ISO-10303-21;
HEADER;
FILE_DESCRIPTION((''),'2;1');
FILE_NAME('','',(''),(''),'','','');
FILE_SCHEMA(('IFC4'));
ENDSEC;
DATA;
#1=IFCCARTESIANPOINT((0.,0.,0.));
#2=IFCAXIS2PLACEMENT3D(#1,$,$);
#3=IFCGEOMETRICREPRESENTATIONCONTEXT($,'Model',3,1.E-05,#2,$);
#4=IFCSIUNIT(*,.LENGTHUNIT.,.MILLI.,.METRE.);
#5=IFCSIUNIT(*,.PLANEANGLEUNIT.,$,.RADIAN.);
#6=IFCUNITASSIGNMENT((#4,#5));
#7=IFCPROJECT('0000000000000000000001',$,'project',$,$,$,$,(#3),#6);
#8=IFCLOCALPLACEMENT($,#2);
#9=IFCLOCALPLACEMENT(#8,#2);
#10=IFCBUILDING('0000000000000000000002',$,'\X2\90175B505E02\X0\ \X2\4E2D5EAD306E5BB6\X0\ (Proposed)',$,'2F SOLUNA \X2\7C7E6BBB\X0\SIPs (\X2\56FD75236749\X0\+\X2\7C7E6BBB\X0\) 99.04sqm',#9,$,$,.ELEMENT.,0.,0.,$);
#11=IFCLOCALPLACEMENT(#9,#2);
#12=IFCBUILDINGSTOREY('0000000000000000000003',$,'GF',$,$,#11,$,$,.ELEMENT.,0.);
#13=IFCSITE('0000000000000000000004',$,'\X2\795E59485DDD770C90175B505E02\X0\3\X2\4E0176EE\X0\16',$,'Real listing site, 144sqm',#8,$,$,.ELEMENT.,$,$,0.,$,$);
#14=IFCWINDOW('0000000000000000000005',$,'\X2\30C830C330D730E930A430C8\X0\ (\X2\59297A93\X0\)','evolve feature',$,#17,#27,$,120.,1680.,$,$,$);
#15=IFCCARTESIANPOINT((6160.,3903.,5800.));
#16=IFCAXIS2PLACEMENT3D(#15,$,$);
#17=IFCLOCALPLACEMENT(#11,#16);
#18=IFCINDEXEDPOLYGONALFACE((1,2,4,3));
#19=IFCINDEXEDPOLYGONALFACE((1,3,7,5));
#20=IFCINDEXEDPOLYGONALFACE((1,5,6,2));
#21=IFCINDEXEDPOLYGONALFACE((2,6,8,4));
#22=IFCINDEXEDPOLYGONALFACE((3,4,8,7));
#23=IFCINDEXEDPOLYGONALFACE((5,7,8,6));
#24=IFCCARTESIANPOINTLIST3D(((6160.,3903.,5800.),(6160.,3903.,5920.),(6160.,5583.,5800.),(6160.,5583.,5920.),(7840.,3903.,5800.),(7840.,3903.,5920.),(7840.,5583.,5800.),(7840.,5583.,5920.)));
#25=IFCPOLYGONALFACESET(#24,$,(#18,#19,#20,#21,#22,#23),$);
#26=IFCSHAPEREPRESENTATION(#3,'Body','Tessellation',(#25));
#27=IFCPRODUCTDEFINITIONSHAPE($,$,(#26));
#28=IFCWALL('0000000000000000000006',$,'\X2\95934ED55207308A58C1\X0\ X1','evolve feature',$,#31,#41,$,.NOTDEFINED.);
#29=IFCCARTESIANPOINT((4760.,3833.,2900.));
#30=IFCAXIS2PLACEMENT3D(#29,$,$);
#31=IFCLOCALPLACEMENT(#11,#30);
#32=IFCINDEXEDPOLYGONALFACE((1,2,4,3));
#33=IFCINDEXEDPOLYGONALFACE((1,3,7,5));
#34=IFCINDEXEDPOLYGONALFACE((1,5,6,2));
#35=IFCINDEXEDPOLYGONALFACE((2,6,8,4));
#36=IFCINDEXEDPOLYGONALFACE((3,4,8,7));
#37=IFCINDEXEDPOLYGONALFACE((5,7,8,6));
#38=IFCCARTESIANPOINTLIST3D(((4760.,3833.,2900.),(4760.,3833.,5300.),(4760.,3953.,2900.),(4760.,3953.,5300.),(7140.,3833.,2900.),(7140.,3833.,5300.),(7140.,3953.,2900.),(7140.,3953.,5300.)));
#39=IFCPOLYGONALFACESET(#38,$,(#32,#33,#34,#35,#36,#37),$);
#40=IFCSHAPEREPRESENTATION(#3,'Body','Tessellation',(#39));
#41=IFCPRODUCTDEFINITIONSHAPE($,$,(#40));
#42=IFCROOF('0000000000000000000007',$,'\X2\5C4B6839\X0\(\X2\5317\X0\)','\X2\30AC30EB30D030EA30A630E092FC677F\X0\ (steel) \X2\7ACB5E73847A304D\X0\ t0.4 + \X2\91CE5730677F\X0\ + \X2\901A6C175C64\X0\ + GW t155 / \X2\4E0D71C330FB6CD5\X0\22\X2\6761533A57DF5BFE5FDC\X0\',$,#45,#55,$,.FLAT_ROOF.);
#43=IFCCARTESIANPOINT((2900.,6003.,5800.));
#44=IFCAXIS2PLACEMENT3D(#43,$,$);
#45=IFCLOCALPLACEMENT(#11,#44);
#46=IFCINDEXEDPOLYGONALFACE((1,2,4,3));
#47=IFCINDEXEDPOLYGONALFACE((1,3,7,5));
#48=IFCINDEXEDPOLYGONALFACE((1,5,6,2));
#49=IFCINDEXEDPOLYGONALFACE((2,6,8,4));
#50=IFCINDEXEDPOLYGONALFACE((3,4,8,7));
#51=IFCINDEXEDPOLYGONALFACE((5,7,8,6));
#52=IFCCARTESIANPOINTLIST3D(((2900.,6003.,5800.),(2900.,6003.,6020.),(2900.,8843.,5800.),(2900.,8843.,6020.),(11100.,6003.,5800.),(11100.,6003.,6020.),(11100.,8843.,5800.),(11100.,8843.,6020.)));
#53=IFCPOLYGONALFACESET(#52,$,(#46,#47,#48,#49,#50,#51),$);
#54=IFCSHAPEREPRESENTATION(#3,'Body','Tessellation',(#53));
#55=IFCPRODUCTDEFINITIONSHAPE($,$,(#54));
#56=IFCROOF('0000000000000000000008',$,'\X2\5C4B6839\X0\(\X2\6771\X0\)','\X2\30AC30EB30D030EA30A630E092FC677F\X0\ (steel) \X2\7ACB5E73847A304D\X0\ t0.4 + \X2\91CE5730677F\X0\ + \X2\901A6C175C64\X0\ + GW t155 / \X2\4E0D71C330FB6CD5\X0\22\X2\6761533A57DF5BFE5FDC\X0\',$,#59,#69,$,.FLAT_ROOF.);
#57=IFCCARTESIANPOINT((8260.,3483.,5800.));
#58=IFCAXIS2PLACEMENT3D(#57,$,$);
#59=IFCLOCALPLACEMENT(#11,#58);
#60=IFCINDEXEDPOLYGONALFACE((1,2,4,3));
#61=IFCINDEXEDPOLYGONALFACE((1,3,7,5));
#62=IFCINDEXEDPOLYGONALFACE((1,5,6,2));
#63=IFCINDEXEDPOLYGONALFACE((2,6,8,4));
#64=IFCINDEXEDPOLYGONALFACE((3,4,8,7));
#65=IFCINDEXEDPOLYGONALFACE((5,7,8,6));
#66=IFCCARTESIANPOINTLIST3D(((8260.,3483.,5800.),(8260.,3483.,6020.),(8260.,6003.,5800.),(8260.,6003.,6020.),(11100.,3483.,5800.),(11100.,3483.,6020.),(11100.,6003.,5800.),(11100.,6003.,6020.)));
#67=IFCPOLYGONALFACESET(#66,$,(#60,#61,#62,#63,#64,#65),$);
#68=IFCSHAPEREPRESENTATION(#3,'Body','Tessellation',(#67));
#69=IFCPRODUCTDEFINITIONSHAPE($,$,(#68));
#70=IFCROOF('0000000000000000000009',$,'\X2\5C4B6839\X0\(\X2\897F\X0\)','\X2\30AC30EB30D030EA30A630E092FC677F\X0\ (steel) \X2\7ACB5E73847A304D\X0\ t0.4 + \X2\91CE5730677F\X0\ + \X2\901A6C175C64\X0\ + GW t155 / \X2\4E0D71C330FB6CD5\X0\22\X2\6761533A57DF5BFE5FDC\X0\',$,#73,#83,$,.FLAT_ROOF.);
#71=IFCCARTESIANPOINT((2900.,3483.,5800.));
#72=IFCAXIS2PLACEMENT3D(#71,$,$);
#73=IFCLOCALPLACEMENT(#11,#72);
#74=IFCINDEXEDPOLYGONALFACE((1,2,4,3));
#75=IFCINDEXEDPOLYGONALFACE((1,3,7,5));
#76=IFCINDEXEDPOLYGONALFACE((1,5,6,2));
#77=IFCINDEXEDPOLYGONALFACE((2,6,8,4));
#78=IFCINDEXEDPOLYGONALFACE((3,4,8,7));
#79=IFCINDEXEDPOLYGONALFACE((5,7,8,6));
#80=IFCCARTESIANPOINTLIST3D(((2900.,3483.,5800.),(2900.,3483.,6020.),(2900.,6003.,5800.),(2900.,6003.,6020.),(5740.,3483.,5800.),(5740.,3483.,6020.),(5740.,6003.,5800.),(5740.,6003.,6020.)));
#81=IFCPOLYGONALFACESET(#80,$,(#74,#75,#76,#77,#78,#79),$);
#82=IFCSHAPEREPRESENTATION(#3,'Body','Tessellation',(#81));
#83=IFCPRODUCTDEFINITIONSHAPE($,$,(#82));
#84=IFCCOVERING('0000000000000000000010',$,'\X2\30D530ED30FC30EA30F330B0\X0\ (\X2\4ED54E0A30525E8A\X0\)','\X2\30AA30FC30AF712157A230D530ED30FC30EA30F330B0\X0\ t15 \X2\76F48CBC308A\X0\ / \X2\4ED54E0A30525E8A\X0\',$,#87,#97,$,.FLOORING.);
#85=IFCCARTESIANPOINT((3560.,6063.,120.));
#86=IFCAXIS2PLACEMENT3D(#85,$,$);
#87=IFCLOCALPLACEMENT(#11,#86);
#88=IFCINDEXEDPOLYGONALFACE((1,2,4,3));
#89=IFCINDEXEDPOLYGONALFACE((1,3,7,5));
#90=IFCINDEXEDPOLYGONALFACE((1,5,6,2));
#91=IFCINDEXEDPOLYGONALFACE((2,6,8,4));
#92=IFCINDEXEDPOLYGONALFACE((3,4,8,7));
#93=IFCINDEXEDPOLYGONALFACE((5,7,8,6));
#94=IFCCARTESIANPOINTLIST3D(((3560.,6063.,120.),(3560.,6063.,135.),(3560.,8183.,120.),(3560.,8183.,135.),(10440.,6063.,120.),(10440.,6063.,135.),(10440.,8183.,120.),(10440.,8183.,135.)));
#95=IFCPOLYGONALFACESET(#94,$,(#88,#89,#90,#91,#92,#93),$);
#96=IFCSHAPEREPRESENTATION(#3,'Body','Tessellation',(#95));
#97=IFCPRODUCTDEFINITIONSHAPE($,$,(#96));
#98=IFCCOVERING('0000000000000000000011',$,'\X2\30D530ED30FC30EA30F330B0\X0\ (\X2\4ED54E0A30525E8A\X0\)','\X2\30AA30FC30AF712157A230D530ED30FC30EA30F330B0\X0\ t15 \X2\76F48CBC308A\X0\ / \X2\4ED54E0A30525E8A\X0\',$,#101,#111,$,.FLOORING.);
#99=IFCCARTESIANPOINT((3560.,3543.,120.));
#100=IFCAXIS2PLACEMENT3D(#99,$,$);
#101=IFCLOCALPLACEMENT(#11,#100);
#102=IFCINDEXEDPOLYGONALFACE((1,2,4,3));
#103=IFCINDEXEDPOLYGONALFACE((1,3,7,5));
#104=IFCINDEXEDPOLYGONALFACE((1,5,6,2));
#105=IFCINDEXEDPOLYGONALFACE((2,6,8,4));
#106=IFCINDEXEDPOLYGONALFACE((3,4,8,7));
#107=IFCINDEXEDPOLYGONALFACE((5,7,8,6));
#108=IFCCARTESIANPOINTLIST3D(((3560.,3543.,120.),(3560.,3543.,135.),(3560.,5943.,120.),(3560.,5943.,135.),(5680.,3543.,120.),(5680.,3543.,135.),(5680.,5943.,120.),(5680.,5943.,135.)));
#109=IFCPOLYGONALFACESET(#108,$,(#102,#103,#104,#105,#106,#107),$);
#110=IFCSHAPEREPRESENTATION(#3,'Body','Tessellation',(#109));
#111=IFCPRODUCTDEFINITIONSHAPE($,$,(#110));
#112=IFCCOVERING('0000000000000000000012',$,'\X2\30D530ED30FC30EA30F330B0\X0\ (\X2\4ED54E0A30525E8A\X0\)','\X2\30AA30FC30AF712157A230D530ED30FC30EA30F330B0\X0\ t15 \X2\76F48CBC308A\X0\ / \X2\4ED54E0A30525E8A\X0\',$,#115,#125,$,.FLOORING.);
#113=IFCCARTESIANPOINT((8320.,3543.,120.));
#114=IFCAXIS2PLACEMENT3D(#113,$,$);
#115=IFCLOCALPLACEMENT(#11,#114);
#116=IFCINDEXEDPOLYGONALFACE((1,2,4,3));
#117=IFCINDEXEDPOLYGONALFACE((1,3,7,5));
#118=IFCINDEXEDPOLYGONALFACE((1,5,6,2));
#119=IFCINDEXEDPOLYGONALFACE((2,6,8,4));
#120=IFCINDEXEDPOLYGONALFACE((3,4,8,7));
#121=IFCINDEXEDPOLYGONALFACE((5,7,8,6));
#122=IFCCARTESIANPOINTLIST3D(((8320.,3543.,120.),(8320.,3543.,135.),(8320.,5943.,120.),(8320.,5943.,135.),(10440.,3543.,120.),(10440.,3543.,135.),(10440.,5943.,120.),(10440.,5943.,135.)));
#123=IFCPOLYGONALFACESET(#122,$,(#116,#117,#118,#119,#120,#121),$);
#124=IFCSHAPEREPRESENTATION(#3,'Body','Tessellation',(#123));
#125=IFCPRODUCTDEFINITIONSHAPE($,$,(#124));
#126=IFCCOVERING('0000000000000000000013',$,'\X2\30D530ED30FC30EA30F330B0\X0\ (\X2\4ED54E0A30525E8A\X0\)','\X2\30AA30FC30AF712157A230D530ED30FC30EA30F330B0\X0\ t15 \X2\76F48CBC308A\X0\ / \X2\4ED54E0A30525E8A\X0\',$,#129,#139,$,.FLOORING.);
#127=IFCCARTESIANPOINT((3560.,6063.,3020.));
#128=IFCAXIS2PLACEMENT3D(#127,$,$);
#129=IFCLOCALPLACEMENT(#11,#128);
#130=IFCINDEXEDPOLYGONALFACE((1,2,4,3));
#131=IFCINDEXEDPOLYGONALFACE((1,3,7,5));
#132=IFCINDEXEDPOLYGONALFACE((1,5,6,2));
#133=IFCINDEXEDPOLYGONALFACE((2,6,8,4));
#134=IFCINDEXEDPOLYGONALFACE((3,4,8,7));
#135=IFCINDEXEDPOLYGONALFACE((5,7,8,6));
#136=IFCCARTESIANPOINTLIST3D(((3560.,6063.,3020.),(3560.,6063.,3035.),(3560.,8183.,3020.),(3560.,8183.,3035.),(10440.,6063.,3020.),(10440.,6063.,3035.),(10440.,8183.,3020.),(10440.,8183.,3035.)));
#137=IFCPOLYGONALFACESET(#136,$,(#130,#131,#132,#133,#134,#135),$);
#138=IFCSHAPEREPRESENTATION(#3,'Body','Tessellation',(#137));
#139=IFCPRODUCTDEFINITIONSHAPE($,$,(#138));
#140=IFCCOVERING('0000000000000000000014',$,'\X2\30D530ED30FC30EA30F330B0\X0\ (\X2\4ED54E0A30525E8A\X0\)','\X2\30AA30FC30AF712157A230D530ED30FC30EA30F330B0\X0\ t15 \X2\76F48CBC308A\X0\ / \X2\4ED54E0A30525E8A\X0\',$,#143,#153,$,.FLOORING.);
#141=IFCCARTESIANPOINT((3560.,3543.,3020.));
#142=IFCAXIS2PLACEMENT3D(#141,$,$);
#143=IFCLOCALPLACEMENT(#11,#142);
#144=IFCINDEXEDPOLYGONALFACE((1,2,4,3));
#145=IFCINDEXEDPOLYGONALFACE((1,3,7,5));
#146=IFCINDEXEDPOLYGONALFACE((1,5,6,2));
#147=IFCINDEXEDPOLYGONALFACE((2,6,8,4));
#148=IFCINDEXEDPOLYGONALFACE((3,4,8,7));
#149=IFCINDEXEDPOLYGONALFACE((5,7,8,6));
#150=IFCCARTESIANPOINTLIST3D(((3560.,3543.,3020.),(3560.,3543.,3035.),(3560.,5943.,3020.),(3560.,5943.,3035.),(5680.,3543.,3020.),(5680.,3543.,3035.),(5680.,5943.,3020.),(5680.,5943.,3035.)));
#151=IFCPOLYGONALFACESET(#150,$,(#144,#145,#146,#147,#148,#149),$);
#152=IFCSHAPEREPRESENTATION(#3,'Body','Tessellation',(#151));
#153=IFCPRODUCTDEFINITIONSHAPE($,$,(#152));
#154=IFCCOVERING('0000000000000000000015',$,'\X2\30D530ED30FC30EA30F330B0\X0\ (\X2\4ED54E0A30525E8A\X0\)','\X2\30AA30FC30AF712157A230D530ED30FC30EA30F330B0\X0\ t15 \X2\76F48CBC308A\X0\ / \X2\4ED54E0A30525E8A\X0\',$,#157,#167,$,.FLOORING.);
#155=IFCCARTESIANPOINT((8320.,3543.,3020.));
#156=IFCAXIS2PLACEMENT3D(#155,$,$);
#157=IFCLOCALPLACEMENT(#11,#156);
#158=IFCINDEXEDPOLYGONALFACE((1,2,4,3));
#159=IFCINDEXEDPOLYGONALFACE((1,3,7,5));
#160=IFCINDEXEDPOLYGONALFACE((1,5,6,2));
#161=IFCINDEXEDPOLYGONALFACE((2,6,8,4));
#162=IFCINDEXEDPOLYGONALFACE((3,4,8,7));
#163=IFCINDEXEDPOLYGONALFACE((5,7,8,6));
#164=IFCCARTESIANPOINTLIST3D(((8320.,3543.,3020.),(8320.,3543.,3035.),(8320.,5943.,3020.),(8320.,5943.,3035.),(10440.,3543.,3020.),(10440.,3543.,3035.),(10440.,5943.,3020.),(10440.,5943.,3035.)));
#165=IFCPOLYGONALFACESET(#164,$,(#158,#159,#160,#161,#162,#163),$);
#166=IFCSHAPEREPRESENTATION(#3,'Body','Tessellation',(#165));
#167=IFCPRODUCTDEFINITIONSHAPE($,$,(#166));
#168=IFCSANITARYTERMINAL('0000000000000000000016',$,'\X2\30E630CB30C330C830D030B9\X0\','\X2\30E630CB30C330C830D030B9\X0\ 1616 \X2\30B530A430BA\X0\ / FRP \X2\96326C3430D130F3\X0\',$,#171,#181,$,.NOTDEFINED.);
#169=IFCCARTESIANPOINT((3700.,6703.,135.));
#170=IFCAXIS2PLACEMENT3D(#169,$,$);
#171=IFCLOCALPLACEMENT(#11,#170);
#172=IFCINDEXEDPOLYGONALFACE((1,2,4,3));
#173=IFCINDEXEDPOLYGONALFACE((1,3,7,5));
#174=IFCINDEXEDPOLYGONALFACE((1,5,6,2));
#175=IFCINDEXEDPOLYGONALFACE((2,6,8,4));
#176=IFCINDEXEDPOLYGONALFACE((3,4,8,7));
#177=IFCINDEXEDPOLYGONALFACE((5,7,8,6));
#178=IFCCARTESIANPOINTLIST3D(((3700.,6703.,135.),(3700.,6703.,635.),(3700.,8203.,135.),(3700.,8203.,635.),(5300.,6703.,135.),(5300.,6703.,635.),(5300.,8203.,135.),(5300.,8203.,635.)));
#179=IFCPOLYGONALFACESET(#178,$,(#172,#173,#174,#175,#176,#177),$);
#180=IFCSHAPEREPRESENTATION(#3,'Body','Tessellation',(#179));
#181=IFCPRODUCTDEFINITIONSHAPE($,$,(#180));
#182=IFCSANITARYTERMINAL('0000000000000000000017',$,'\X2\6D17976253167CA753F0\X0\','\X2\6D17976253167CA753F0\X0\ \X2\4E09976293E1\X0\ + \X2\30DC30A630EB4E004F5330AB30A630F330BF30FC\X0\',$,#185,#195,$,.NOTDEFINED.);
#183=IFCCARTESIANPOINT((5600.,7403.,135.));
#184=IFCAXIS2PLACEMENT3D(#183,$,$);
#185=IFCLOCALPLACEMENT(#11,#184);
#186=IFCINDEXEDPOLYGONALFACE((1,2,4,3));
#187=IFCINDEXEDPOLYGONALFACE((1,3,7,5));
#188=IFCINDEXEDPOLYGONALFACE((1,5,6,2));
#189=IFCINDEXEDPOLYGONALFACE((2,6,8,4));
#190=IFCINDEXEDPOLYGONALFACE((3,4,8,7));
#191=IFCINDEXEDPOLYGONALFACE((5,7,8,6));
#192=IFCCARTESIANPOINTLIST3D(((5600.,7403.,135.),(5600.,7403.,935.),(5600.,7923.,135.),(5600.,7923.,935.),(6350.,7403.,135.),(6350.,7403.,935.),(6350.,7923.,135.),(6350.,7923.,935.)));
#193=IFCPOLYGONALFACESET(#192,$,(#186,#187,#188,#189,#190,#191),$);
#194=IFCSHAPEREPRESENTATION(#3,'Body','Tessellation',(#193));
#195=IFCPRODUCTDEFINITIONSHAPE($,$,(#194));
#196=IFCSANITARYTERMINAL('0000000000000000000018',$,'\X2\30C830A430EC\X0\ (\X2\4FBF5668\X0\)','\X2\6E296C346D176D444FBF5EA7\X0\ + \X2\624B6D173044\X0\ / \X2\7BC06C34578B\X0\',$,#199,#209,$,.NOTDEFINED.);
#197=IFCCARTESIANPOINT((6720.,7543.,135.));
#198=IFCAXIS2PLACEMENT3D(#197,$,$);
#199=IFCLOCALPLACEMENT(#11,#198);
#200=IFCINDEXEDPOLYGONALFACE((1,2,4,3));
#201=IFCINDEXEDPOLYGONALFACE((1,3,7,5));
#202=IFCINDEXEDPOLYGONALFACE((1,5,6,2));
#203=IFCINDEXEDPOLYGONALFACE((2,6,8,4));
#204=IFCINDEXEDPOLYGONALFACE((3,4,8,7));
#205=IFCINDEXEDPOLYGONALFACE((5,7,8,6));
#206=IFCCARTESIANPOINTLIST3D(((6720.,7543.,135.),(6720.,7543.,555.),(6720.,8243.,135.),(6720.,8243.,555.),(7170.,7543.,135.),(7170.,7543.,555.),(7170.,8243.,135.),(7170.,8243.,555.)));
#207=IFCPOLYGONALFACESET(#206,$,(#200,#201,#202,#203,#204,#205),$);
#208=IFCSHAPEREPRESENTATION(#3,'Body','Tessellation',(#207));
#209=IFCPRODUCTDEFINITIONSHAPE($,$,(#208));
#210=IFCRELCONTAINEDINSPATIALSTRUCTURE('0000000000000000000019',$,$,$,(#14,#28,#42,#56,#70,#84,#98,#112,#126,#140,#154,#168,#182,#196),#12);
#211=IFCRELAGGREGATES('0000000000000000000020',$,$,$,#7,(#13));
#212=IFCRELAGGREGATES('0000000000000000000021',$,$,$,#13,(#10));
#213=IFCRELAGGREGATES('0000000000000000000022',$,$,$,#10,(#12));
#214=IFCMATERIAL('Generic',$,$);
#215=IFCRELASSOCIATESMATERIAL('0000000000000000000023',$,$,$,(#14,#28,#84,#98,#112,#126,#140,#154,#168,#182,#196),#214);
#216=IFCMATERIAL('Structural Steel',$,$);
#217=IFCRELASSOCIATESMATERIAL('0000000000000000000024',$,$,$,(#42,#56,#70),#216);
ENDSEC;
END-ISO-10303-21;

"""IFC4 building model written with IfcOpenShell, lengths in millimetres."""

from ifc_helpers import new_model, si_unit, frame, frame_2d, origin, place, context, project, spatial, rectangle, extrude, material, element, save


model = new_model("IFC4")

# Units and contexts
model_context = context("Model", 3, precision=1e-05, world=origin())
ifc_project = project(units=[si_unit("LENGTHUNIT", "METRE", prefix="MILLI"), si_unit("PLANEANGLEUNIT", "RADIAN")], contexts=[model_context])

# Site, building, storey
site_placement = place(None, origin())
site = spatial("IfcSite", under=ifc_project, at=site_placement, Name="神奈川県逗子市3丁目16", ObjectType="Real listing site, 144sqm", CompositionType="ELEMENT", RefElevation=0.0)
building_placement = place(site_placement, origin())
building = spatial("IfcBuilding", under=site, at=building_placement, Name="逗子市 中庭の家 (Proposed)", ObjectType="2F SOLUNA 籾殻SIPs (国産杉+籾殻) 99.04sqm", CompositionType="ELEMENT", ElevationOfRefHeight=0.0, ElevationOfTerrain=0.0)
storey_placement = place(building_placement, origin())
storey = spatial("IfcBuildingStorey", under=building, at=storey_placement, Name="GF", CompositionType="ELEMENT", Elevation=0.0)

# Window
ifc_material_1 = material(Name="Generic")
window_1_placement = place(storey_placement, frame((6160.0, 3903.0, 5800.0)))
element("IfcWindow", 1, at=window_1_placement, inside=storey, material=ifc_material_1, Name="トップライト (天窓)", Description="evolve feature", OverallHeight=120.0, OverallWidth=1680.0, context=model_context, shape_type="SweptSolid", body=[
    extrude(rectangle(XDim=1680.0, YDim=1680.0, at=frame_2d((840.0, 840.0))), frame((6160.0, 3903.0, 5800.0)), (0.0, 0.0, 1.0), 120.0),
])

# Wall
wall_1_placement = place(storey_placement, frame((4760.0, 3833.0, 2900.0)))
element("IfcWall", 2, at=wall_1_placement, inside=storey, material=ifc_material_1, Name="間仕切り壁 X1", Description="evolve feature", PredefinedType="NOTDEFINED", context=model_context, shape_type="SweptSolid", body=[
    extrude(rectangle(XDim=2380.0, YDim=120.0, at=frame_2d((1190.0, 60.0))), frame((4760.0, 3833.0, 2900.0)), (0.0, 0.0, 1.0), 2400.0),
])

# Roofs
ifc_material_2 = material(Name="Structural Steel")
roof_1_placement = place(storey_placement, frame((2900.0, 6003.0, 5800.0)))
element("IfcRoof", 3, at=roof_1_placement, inside=storey, material=ifc_material_2, Name="屋根(北)", Description="ガルバリウム鋼板 (steel) 立平葺き t0.4 + 野地板 + 通気層 + GW t155 / 不燃・法22条区域対応", PredefinedType="FLAT_ROOF", context=model_context, shape_type="SweptSolid", body=[
    extrude(rectangle(XDim=8200.0, YDim=2840.0, at=frame_2d((4100.0, 1420.0))), frame((2900.0, 6003.0, 5800.0)), (0.0, 0.0, 1.0), 220.0),
])
roof_2_placement = place(storey_placement, frame((8260.0, 3483.0, 5800.0)))
element("IfcRoof", 4, at=roof_2_placement, inside=storey, material=ifc_material_2, Name="屋根(東)", Description="ガルバリウム鋼板 (steel) 立平葺き t0.4 + 野地板 + 通気層 + GW t155 / 不燃・法22条区域対応", PredefinedType="FLAT_ROOF", context=model_context, shape_type="SweptSolid", body=[
    extrude(rectangle(XDim=2840.0, YDim=2520.0, at=frame_2d((1420.0, 1260.0))), frame((8260.0, 3483.0, 5800.0)), (0.0, 0.0, 1.0), 220.0),
])
roof_3_placement = place(storey_placement, frame((2900.0, 3483.0, 5800.0)))
element("IfcRoof", 5, at=roof_3_placement, inside=storey, material=ifc_material_2, Name="屋根(西)", Description="ガルバリウム鋼板 (steel) 立平葺き t0.4 + 野地板 + 通気層 + GW t155 / 不燃・法22条区域対応", PredefinedType="FLAT_ROOF", context=model_context, shape_type="SweptSolid", body=[
    extrude(rectangle(XDim=2840.0, YDim=2520.0, at=frame_2d((1420.0, 1260.0))), frame((2900.0, 3483.0, 5800.0)), (0.0, 0.0, 1.0), 220.0),
])

# Coverings
covering_1_placement = place(storey_placement, frame((3560.0, 6063.0, 120.0)))
element("IfcCovering", 6, at=covering_1_placement, inside=storey, material=ifc_material_1, Name="フローリング (仕上げ床)", Description="オーク無垢フローリング t15 直貼り / 仕上げ床", PredefinedType="FLOORING", context=model_context, shape_type="SweptSolid", body=[
    extrude(rectangle(XDim=6880.0, YDim=2120.0, at=frame_2d((3440.0, 1060.0))), frame((3560.0, 6063.0, 120.0)), (0.0, 0.0, 1.0), 15.0),
])
covering_2_placement = place(storey_placement, frame((3560.0, 3543.0, 120.0)))
element("IfcCovering", 7, at=covering_2_placement, inside=storey, material=ifc_material_1, Name="フローリング (仕上げ床)", Description="オーク無垢フローリング t15 直貼り / 仕上げ床", PredefinedType="FLOORING", context=model_context, shape_type="SweptSolid", body=[
    extrude(rectangle(XDim=2120.0, YDim=2400.0, at=frame_2d((1060.0, 1200.0))), frame((3560.0, 3543.0, 120.0)), (0.0, 0.0, 1.0), 15.0),
])
covering_3_placement = place(storey_placement, frame((8320.0, 3543.0, 120.0)))
element("IfcCovering", 8, at=covering_3_placement, inside=storey, material=ifc_material_1, Name="フローリング (仕上げ床)", Description="オーク無垢フローリング t15 直貼り / 仕上げ床", PredefinedType="FLOORING", context=model_context, shape_type="SweptSolid", body=[
    extrude(rectangle(XDim=2120.0, YDim=2400.0, at=frame_2d((1060.0, 1200.0))), frame((8320.0, 3543.0, 120.0)), (0.0, 0.0, 1.0), 15.0),
])
covering_4_placement = place(storey_placement, frame((3560.0, 6063.0, 3020.0)))
element("IfcCovering", 9, at=covering_4_placement, inside=storey, material=ifc_material_1, Name="フローリング (仕上げ床)", Description="オーク無垢フローリング t15 直貼り / 仕上げ床", PredefinedType="FLOORING", context=model_context, shape_type="SweptSolid", body=[
    extrude(rectangle(XDim=6880.0, YDim=2120.0, at=frame_2d((3440.0, 1060.0))), frame((3560.0, 6063.0, 3020.0)), (0.0, 0.0, 1.0), 15.0),
])
covering_5_placement = place(storey_placement, frame((3560.0, 3543.0, 3020.0)))
element("IfcCovering", 10, at=covering_5_placement, inside=storey, material=ifc_material_1, Name="フローリング (仕上げ床)", Description="オーク無垢フローリング t15 直貼り / 仕上げ床", PredefinedType="FLOORING", context=model_context, shape_type="SweptSolid", body=[
    extrude(rectangle(XDim=2120.0, YDim=2400.0, at=frame_2d((1060.0, 1200.0))), frame((3560.0, 3543.0, 3020.0)), (0.0, 0.0, 1.0), 15.0),
])
covering_6_placement = place(storey_placement, frame((8320.0, 3543.0, 3020.0)))
element("IfcCovering", 11, at=covering_6_placement, inside=storey, material=ifc_material_1, Name="フローリング (仕上げ床)", Description="オーク無垢フローリング t15 直貼り / 仕上げ床", PredefinedType="FLOORING", context=model_context, shape_type="SweptSolid", body=[
    extrude(rectangle(XDim=2120.0, YDim=2400.0, at=frame_2d((1060.0, 1200.0))), frame((8320.0, 3543.0, 3020.0)), (0.0, 0.0, 1.0), 15.0),
])

# Sanitary terminals
sanitary_terminal_1_placement = place(storey_placement, frame((3700.0, 6703.0, 135.0)))
element("IfcSanitaryTerminal", 12, at=sanitary_terminal_1_placement, inside=storey, material=ifc_material_1, Name="ユニットバス", Description="ユニットバス 1616 サイズ / FRP 防水パン", PredefinedType="NOTDEFINED", context=model_context, shape_type="SweptSolid", body=[
    extrude(rectangle(XDim=1600.0, YDim=1500.0, at=frame_2d((800.0, 750.0))), frame((3700.0, 6703.0, 135.0)), (0.0, 0.0, 1.0), 500.0),
])
sanitary_terminal_2_placement = place(storey_placement, frame((5600.0, 7403.0, 135.0)))
element("IfcSanitaryTerminal", 13, at=sanitary_terminal_2_placement, inside=storey, material=ifc_material_1, Name="洗面化粧台", Description="洗面化粧台 三面鏡 + ボウル一体カウンター", PredefinedType="NOTDEFINED", context=model_context, shape_type="SweptSolid", body=[
    extrude(rectangle(XDim=750.0, YDim=520.0, at=frame_2d((375.0, 260.0))), frame((5600.0, 7403.0, 135.0)), (0.0, 0.0, 1.0), 800.0),
])
sanitary_terminal_3_placement = place(storey_placement, frame((6720.0, 7543.0, 135.0)))
element("IfcSanitaryTerminal", 14, at=sanitary_terminal_3_placement, inside=storey, material=ifc_material_1, Name="トイレ (便器)", Description="温水洗浄便座 + 手洗い / 節水型", PredefinedType="NOTDEFINED", context=model_context, shape_type="SweptSolid", body=[
    extrude(rectangle(XDim=450.0, YDim=700.0, at=frame_2d((225.0, 350.0))), frame((6720.0, 7543.0, 135.0)), (0.0, 0.0, 1.0), 420.0),
])

save(model, "model.ifc")
